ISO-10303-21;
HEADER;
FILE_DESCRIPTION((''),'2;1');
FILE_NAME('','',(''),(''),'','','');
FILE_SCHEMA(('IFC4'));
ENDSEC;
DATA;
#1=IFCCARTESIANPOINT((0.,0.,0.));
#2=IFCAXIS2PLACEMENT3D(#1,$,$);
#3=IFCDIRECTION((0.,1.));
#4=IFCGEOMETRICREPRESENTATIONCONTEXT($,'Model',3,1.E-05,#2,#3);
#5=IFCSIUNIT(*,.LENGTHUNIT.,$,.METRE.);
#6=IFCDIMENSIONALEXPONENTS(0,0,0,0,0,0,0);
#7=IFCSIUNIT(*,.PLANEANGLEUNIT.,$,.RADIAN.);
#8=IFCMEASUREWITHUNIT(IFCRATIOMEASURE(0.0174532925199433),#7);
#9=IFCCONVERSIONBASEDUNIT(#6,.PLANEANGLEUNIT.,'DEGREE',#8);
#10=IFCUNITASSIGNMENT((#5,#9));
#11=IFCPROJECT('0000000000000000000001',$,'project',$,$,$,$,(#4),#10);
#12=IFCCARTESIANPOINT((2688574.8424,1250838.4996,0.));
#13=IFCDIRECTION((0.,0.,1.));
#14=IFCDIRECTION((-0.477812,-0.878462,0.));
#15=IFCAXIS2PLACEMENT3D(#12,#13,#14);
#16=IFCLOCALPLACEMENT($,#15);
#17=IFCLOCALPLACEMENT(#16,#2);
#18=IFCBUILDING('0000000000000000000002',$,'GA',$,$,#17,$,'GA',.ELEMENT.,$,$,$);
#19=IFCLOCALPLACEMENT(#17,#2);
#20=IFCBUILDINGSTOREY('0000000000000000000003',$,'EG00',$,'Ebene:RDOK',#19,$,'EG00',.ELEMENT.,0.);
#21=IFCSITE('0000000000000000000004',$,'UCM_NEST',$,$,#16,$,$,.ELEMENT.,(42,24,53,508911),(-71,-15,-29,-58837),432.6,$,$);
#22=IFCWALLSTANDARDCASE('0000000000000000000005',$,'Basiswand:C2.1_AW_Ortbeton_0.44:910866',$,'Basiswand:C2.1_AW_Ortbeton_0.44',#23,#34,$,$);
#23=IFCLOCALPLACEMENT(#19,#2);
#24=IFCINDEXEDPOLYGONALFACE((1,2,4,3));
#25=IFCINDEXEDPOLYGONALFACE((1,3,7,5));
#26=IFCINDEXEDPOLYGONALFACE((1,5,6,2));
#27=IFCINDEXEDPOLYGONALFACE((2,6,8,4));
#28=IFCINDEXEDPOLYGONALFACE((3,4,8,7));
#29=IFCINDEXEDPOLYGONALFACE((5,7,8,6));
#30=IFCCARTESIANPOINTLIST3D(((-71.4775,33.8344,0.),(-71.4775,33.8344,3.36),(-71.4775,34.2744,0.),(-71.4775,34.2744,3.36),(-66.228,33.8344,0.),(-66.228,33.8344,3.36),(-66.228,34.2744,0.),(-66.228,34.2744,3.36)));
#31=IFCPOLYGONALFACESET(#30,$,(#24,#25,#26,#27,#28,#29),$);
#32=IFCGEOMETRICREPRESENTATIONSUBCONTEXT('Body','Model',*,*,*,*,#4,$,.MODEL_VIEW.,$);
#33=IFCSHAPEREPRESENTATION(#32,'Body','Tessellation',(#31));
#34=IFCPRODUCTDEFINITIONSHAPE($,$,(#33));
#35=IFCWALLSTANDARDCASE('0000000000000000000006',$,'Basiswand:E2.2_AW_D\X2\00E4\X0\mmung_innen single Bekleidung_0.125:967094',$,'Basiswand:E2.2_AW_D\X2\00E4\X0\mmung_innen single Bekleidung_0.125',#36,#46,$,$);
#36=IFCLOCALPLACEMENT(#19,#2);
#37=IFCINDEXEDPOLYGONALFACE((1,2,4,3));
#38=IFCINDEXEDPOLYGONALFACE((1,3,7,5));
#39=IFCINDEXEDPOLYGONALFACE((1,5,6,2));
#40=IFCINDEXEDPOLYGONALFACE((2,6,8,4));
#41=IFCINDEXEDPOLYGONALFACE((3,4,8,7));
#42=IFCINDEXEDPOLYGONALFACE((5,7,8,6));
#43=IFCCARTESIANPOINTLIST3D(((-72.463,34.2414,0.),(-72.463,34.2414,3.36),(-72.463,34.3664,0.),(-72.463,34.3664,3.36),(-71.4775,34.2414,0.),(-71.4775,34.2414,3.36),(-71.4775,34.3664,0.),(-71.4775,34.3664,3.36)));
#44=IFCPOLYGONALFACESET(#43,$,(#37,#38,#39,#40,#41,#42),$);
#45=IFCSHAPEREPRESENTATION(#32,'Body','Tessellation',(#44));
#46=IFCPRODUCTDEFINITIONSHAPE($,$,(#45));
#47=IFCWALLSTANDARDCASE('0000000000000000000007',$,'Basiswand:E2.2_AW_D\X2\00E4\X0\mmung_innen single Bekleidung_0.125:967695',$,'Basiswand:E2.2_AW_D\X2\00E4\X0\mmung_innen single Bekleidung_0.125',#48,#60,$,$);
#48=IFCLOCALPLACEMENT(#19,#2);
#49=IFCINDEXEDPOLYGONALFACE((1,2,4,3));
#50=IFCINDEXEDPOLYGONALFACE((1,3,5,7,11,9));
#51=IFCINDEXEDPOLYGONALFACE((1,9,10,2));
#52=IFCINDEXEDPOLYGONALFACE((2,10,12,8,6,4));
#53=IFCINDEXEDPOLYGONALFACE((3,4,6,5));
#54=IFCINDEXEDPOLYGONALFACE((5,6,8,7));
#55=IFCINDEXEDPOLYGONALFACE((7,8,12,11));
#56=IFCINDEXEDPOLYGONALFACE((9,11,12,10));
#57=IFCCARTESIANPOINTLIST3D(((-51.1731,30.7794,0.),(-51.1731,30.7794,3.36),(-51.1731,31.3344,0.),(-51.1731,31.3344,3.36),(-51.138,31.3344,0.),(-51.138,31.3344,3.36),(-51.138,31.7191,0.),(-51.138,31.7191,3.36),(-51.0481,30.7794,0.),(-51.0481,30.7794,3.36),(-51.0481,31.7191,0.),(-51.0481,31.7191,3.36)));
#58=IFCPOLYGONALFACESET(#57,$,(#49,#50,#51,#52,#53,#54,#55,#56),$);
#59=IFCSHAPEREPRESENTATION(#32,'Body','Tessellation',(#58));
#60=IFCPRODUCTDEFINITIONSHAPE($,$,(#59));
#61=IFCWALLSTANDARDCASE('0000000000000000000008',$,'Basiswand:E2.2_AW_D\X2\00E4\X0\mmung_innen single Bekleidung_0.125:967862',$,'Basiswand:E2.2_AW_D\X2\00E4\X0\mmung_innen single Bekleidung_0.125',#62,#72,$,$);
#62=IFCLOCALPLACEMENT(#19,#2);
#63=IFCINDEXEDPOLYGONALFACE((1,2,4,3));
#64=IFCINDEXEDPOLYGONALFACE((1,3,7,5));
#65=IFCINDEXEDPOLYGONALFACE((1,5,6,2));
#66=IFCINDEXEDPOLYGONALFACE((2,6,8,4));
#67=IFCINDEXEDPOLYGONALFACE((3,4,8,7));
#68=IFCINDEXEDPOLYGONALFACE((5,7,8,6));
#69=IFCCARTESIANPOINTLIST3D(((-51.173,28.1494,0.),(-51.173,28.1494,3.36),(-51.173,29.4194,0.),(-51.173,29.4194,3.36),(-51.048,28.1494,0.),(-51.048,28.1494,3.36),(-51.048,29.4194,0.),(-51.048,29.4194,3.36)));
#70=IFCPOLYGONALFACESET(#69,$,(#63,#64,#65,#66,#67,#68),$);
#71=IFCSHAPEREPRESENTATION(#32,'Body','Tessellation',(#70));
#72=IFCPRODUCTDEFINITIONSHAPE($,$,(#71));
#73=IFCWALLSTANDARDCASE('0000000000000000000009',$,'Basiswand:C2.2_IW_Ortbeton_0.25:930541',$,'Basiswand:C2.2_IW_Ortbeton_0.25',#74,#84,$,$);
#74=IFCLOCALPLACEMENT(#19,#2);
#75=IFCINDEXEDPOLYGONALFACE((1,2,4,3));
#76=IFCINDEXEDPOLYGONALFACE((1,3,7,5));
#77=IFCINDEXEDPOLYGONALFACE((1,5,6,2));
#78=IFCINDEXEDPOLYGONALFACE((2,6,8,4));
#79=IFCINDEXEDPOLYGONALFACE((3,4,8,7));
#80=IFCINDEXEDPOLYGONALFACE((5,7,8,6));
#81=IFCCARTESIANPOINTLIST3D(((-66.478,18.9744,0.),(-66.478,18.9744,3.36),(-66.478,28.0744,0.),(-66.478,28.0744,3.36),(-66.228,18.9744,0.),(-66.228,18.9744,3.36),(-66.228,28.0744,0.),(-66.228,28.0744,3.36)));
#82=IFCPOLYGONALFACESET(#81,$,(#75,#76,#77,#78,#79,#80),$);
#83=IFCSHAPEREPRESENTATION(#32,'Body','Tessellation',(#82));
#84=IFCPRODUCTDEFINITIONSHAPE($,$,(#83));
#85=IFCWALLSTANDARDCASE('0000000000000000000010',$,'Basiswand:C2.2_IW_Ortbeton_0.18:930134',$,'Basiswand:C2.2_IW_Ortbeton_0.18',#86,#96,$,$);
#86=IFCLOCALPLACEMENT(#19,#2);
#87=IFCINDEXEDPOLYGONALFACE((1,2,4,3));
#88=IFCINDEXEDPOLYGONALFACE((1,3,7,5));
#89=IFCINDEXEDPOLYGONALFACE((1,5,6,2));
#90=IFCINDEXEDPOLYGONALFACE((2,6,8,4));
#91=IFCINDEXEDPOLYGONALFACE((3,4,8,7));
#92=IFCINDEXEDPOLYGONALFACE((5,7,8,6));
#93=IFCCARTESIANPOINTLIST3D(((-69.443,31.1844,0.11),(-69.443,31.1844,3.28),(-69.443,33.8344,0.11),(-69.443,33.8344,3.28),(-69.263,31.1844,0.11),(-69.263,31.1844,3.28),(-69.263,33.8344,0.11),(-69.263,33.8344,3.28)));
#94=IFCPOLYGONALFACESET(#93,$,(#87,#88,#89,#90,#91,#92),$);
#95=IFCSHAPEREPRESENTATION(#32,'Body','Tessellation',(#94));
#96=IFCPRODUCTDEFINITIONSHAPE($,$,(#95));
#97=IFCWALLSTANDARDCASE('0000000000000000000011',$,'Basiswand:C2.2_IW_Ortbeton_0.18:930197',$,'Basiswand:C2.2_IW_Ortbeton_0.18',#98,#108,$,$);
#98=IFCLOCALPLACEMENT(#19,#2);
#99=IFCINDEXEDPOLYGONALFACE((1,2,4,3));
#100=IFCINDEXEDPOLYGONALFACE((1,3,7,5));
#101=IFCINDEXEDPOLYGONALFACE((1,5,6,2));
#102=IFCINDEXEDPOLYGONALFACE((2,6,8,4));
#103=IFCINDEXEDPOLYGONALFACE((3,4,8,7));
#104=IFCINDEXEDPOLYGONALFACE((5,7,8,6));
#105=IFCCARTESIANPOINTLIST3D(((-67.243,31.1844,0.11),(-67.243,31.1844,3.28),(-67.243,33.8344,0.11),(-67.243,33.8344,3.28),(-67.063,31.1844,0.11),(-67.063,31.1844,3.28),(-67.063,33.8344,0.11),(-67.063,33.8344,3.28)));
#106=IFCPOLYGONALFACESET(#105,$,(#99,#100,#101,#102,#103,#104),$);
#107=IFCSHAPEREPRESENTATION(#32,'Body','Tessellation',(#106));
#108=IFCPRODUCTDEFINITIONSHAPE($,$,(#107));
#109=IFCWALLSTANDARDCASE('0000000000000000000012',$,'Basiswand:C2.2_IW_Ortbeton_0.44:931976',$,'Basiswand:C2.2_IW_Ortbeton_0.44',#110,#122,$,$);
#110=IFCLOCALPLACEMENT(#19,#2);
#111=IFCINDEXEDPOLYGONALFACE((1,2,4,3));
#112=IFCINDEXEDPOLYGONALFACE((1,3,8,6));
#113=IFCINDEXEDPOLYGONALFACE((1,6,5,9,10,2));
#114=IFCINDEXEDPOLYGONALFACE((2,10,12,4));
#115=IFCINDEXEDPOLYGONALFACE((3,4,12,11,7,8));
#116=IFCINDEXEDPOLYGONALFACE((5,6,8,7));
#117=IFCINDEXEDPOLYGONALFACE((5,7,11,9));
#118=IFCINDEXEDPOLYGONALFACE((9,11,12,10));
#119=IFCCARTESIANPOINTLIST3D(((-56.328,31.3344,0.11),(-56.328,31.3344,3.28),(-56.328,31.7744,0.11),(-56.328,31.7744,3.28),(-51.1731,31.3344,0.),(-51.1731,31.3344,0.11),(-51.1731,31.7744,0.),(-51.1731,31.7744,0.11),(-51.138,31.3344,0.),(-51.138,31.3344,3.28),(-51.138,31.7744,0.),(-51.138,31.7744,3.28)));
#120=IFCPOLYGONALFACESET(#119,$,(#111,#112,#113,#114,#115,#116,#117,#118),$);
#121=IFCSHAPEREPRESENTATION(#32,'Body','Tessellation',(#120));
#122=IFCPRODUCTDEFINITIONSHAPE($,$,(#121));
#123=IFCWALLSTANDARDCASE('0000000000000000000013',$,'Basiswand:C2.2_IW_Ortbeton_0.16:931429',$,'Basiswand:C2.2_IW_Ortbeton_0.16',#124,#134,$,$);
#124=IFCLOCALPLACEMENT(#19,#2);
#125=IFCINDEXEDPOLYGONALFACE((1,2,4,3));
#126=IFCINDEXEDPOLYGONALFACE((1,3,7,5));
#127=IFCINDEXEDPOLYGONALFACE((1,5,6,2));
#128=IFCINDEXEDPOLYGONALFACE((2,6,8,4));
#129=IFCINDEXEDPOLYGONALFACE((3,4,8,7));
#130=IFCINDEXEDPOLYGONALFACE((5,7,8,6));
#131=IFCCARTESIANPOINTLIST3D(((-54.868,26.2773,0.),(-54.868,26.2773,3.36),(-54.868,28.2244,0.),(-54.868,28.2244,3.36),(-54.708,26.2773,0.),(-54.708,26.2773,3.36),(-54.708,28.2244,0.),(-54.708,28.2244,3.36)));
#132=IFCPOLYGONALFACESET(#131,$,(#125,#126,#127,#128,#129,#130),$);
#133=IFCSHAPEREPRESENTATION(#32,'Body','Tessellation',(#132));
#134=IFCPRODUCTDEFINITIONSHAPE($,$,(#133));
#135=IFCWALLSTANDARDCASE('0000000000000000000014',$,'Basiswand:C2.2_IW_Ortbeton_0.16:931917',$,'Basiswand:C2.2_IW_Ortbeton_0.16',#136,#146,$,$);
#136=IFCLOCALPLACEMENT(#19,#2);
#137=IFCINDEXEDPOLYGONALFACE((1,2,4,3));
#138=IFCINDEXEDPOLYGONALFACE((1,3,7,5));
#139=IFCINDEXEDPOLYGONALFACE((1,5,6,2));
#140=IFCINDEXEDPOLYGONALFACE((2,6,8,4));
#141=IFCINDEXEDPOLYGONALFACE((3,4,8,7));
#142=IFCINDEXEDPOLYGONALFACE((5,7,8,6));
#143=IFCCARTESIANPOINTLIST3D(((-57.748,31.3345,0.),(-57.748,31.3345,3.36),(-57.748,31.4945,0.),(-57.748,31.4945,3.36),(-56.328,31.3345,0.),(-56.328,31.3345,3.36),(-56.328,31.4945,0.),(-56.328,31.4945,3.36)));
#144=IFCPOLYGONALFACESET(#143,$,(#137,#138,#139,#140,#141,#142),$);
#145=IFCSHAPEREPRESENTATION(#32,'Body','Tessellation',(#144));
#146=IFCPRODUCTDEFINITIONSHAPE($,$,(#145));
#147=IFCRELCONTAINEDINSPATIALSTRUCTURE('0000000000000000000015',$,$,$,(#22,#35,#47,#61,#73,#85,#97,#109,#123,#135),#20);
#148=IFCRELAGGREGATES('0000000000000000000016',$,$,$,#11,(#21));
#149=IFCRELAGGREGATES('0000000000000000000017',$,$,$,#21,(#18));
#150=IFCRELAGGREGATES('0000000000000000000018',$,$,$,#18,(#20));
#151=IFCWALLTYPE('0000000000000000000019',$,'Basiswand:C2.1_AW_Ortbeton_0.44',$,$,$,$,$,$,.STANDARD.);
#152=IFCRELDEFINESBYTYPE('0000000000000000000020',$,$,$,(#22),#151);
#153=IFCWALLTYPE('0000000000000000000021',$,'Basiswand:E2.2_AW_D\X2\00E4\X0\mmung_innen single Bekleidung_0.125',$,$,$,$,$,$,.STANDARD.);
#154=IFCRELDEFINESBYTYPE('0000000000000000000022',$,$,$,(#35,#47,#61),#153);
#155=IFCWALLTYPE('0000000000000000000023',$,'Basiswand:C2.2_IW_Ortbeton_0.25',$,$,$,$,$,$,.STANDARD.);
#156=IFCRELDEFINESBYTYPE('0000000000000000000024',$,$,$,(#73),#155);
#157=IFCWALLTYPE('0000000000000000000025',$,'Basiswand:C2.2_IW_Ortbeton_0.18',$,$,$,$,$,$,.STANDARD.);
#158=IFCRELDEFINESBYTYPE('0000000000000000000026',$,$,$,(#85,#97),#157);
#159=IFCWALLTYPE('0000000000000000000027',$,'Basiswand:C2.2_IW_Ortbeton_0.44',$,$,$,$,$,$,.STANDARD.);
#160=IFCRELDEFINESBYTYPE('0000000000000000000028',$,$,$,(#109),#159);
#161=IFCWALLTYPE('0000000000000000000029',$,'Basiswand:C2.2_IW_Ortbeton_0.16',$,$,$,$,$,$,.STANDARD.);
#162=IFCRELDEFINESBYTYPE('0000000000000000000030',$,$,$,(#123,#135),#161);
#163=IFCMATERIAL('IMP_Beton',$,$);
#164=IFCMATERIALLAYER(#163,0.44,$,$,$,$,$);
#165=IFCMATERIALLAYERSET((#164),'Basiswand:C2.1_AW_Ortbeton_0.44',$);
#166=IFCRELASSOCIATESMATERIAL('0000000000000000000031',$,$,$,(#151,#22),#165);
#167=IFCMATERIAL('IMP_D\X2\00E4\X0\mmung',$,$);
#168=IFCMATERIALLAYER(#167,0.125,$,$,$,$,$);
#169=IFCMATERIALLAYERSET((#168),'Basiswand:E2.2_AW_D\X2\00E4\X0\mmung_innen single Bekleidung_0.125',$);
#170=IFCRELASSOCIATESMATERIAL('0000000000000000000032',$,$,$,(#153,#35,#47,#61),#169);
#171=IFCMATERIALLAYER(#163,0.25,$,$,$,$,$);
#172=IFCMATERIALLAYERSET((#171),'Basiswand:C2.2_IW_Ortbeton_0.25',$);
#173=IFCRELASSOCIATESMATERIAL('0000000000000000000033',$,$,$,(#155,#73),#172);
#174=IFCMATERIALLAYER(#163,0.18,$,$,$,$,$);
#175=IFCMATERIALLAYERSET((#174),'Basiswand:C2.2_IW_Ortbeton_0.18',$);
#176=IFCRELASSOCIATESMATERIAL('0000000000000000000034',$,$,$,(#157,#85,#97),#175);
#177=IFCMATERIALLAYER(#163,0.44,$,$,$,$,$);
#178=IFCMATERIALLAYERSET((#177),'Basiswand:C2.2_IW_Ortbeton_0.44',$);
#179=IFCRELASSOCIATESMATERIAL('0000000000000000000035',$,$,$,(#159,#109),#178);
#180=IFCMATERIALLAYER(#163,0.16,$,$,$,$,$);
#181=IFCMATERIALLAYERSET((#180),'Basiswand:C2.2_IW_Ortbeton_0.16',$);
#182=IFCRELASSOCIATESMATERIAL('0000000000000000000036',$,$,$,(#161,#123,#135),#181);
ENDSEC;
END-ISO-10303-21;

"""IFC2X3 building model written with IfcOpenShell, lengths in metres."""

from ifc_helpers import new_model, entity, si_unit, converted_unit, direction, frame, frame_2d, origin, place, context, subcontext, project, spatial, polyline, rectangle, extrude, clip, bounded_halfspace, material, layer, layer_set, layer_usage, type_object, element, save


model = new_model("IFC2X3")

# Units and contexts
model_context = context("Model", 3, precision=1e-05, world=origin(), true_north=direction((0.0, 1.0)))
body_context = subcontext(model_context, "Body", "Model", "MODEL_VIEW")
ifc_project = project(units=[si_unit("LENGTHUNIT", "METRE"), converted_unit("PLANEANGLEUNIT", "DEGREE", entity("IfcRatioMeasure", 0.0174532925199433), si_unit("PLANEANGLEUNIT", "RADIAN"), dimensions=[0, 0, 0, 0, 0, 0, 0])], contexts=[model_context])

# Site, building, storey
site_placement = place(None, frame((2688574.8424, 1250838.4996, 0.0), z_axis=(0.0, 0.0, 1.0), x_axis=(-0.477812, -0.878462, 0.0)))
site = spatial("IfcSite", under=ifc_project, at=site_placement, Name="UCM_NEST", CompositionType="ELEMENT", RefLatitude=(42, 24, 53, 508911), RefLongitude=(-71, -15, -29, -58837), RefElevation=432.6)
building_placement = place(site_placement, origin())
building = spatial("IfcBuilding", under=site, at=building_placement, Name="GA", LongName="GA", CompositionType="ELEMENT")
storey_placement = place(building_placement, origin())
storey = spatial("IfcBuildingStorey", under=building, at=storey_placement, Name="EG00", ObjectType="Ebene:RDOK", LongName="EG00", CompositionType="ELEMENT", Elevation=0.0)

# Shared definitions
ifc_material_1 = material(Name="IMP_Dämmung")
ifc_material_2 = material(Name="IMP_Beton")

# Walls
ifc_layer_1 = layer(ifc_material_2, 0.44)
ifc_layer_set_1 = layer_set([ifc_layer_1], Name="Basiswand:C2.1_AW_Ortbeton_0.44")
ifc_layer_usage_1 = layer_usage(ifc_layer_set_1, "AXIS2", "NEGATIVE", 0.22)
wall_type_1 = type_object("IfcWallType", Name="Basiswand:C2.1_AW_Ortbeton_0.44", PredefinedType="STANDARD", material=ifc_layer_set_1)
wall_1_placement = place(storey_placement, frame((-71.4775, 34.0544, 0.0)))
element("IfcWallStandardCase", 1, at=wall_1_placement, inside=storey, type_object=wall_type_1, material=ifc_layer_usage_1, Name="Basiswand:C2.1_AW_Ortbeton_0.44:910866", ObjectType="Basiswand:C2.1_AW_Ortbeton_0.44", context=body_context, shape_type="SweptSolid", body=[
    extrude(rectangle(XDim=5.2494, YDim=0.44, at=frame_2d((2.6247, 0.0), x_axis=(-1.0, 0.0))), origin(), (0.0, 0.0, 1.0), 3.36),
])
ifc_layer_2 = layer(ifc_material_1, 0.125)
ifc_layer_set_2 = layer_set([ifc_layer_2], Name="Basiswand:E2.2_AW_Dämmung_innen single Bekleidung_0.125")
ifc_layer_usage_2 = layer_usage(ifc_layer_set_2, "AXIS2", "NEGATIVE", 0.0625)
wall_type_2 = type_object("IfcWallType", Name="Basiswand:E2.2_AW_Dämmung_innen single Bekleidung_0.125", PredefinedType="STANDARD", material=ifc_layer_set_2)
wall_2_placement = place(storey_placement, frame((-72.463, 34.3039, 0.0)))
element("IfcWallStandardCase", 2, at=wall_2_placement, inside=storey, type_object=wall_type_2, material=ifc_layer_usage_2, Name="Basiswand:E2.2_AW_Dämmung_innen single Bekleidung_0.125:967094", ObjectType="Basiswand:E2.2_AW_Dämmung_innen single Bekleidung_0.125", context=body_context, shape_type="SweptSolid", body=[
    extrude(rectangle(XDim=0.9856, YDim=0.125, at=frame_2d((0.4928, 0.0), x_axis=(-1.0, 0.0))), origin(), (0.0, 0.0, 1.0), 3.36),
])
ifc_layer_usage_3 = layer_usage(ifc_layer_set_2, "AXIS2", "NEGATIVE", 0.0625)
wall_3_placement = place(storey_placement, frame((-51.1106, 30.7794, 0.0), z_axis=(0.0, 0.0, 1.0), x_axis=(0.0, 1.0, 0.0)))
element("IfcWallStandardCase", 3, at=wall_3_placement, inside=storey, type_object=wall_type_2, material=ifc_layer_usage_3, Name="Basiswand:E2.2_AW_Dämmung_innen single Bekleidung_0.125:967695", ObjectType="Basiswand:E2.2_AW_Dämmung_innen single Bekleidung_0.125", context=body_context, shape_type="Clipping", body=[
    clip(clip(extrude(rectangle(XDim=0.9397, YDim=0.125, at=frame_2d((0.4699, 0.0), x_axis=(-1.0, 0.0))), origin(), (0.0, 0.0, 1.0), 3.36), bounded_halfspace(frame((0.555, 0.0274, 3.36), z_axis=(-1.0, 0.0, 0.0), x_axis=(0.0, -1.0, 0.0)), True, frame((0.555, 0.0274, 3.36), z_axis=(-1.0, 0.0, 0.0), x_axis=(0.0, -1.0, 0.0)), polyline([(0.0, 0.0), (-0.0351, 0.0), (-0.0351, -3.36), (0.0, -3.36), (0.0, 0.0)]))), bounded_halfspace(frame((0.555, 0.0274, 0.0), z_axis=(0.0, -1.0, 0.0), x_axis=(1.0, 0.0, 0.0)), True, frame((0.555, 0.0274, 0.0), z_axis=(0.0, -1.0, 0.0), x_axis=(1.0, 0.0, 0.0)), polyline([(0.0, 0.0), (0.3847, 0.0), (0.3847, 3.36), (0.0, 3.36), (0.0, 0.0)]))),
])
ifc_layer_usage_4 = layer_usage(ifc_layer_set_2, "AXIS2", "NEGATIVE", 0.0625)
wall_4_placement = place(storey_placement, frame((-51.1105, 29.4194, 0.0), z_axis=(0.0, 0.0, 1.0), x_axis=(0.0, -1.0, 0.0)))
element("IfcWallStandardCase", 4, at=wall_4_placement, inside=storey, type_object=wall_type_2, material=ifc_layer_usage_4, Name="Basiswand:E2.2_AW_Dämmung_innen single Bekleidung_0.125:967862", ObjectType="Basiswand:E2.2_AW_Dämmung_innen single Bekleidung_0.125", context=body_context, shape_type="SweptSolid", body=[
    extrude(rectangle(XDim=1.27, YDim=0.125, at=frame_2d((0.635, 0.0), x_axis=(-1.0, 0.0))), origin(), (0.0, 0.0, 1.0), 3.36),
])
ifc_layer_3 = layer(ifc_material_2, 0.25)
ifc_layer_set_3 = layer_set([ifc_layer_3], Name="Basiswand:C2.2_IW_Ortbeton_0.25")
ifc_layer_usage_5 = layer_usage(ifc_layer_set_3, "AXIS2", "NEGATIVE", 0.125)
wall_type_3 = type_object("IfcWallType", Name="Basiswand:C2.2_IW_Ortbeton_0.25", PredefinedType="STANDARD", material=ifc_layer_set_3)
wall_5_placement = place(storey_placement, frame((-66.353, 28.0744, 0.0), z_axis=(0.0, 0.0, 1.0), x_axis=(0.0, -1.0, 0.0)))
element("IfcWallStandardCase", 5, at=wall_5_placement, inside=storey, type_object=wall_type_3, material=ifc_layer_usage_5, Name="Basiswand:C2.2_IW_Ortbeton_0.25:930541", ObjectType="Basiswand:C2.2_IW_Ortbeton_0.25", context=body_context, shape_type="SweptSolid", body=[
    extrude(rectangle(XDim=9.1, YDim=0.25, at=frame_2d((4.55, 0.0), x_axis=(-1.0, 0.0))), origin(), (0.0, 0.0, 1.0), 3.36),
])
ifc_layer_4 = layer(ifc_material_2, 0.18)
ifc_layer_set_4 = layer_set([ifc_layer_4], Name="Basiswand:C2.2_IW_Ortbeton_0.18")
ifc_layer_usage_6 = layer_usage(ifc_layer_set_4, "AXIS2", "NEGATIVE", 0.09)
wall_type_4 = type_object("IfcWallType", Name="Basiswand:C2.2_IW_Ortbeton_0.18", PredefinedType="STANDARD", material=ifc_layer_set_4)
wall_6_placement = place(storey_placement, frame((-69.353, 31.1844, 0.11), z_axis=(0.0, 0.0, 1.0), x_axis=(0.0, 1.0, 0.0)))
element("IfcWallStandardCase", 6, at=wall_6_placement, inside=storey, type_object=wall_type_4, material=ifc_layer_usage_6, Name="Basiswand:C2.2_IW_Ortbeton_0.18:930134", ObjectType="Basiswand:C2.2_IW_Ortbeton_0.18", context=body_context, shape_type="Clipping", body=[
    clip(clip(extrude(rectangle(XDim=2.65, YDim=0.18, at=frame_2d((1.325, 0.0), x_axis=(-1.0, 0.0))), origin(), (0.0, 0.0, 1.0), 3.17), bounded_halfspace(frame((0.0, -0.09, 3.17), z_axis=(0.0, 0.0, -1.0), x_axis=(0.0, 1.0, 0.0)), True, frame((0.0, -0.09, 3.17), z_axis=(0.0, 0.0, -1.0), x_axis=(0.0, 1.0, 0.0)), polyline([(0.0, 0.0), (0.18, 0.0), (0.18, 2.65), (0.0, 2.65), (0.0, 0.0)]))), bounded_halfspace(frame((2.65, -0.09, 0.0), z_axis=(0.0, 0.0, 1.0), x_axis=(0.0, 1.0, 0.0)), True, frame((2.65, -0.09, 0.0), z_axis=(0.0, 0.0, 1.0), x_axis=(0.0, 1.0, 0.0)), polyline([(0.0, 0.0), (0.18, 0.0), (0.18, 2.65), (0.0, 2.65), (0.0, 0.0)]))),
])
ifc_layer_usage_7 = layer_usage(ifc_layer_set_4, "AXIS2", "NEGATIVE", 0.09)
wall_7_placement = place(storey_placement, frame((-67.153, 31.1844, 0.11), z_axis=(0.0, 0.0, 1.0), x_axis=(0.0, 1.0, 0.0)))
element("IfcWallStandardCase", 7, at=wall_7_placement, inside=storey, type_object=wall_type_4, material=ifc_layer_usage_7, Name="Basiswand:C2.2_IW_Ortbeton_0.18:930197", ObjectType="Basiswand:C2.2_IW_Ortbeton_0.18", context=body_context, shape_type="Clipping", body=[
    clip(clip(extrude(rectangle(XDim=2.65, YDim=0.18, at=frame_2d((1.325, 0.0), x_axis=(-1.0, 0.0))), origin(), (0.0, 0.0, 1.0), 3.17), bounded_halfspace(frame((2.65, -0.09, 0.0), z_axis=(0.0, 0.0, 1.0), x_axis=(0.0, 1.0, 0.0)), True, frame((2.65, -0.09, 0.0), z_axis=(0.0, 0.0, 1.0), x_axis=(0.0, 1.0, 0.0)), polyline([(0.0, 0.0), (0.18, 0.0), (0.18, 2.65), (0.0, 2.65), (0.0, 0.0)]))), bounded_halfspace(frame((0.0, -0.09, 3.17), z_axis=(0.0, 0.0, -1.0), x_axis=(0.0, 1.0, 0.0)), True, frame((0.0, -0.09, 3.17), z_axis=(0.0, 0.0, -1.0), x_axis=(0.0, 1.0, 0.0)), polyline([(0.0, 0.0), (0.18, 0.0), (0.18, 2.65), (0.0, 2.65), (0.0, 0.0)]))),
])
ifc_layer_5 = layer(ifc_material_2, 0.44)
ifc_layer_set_5 = layer_set([ifc_layer_5], Name="Basiswand:C2.2_IW_Ortbeton_0.44")
ifc_layer_usage_8 = layer_usage(ifc_layer_set_5, "AXIS2", "NEGATIVE", 0.22)
wall_type_5 = type_object("IfcWallType", Name="Basiswand:C2.2_IW_Ortbeton_0.44", PredefinedType="STANDARD", material=ifc_layer_set_5)
wall_8_placement = place(storey_placement, frame((-56.328, 31.5544, 0.0)))
element("IfcWallStandardCase", 8, at=wall_8_placement, inside=storey, type_object=wall_type_5, material=ifc_layer_usage_8, Name="Basiswand:C2.2_IW_Ortbeton_0.44:931976", ObjectType="Basiswand:C2.2_IW_Ortbeton_0.44", context=body_context, shape_type="Clipping", body=[
    clip(clip(clip(extrude(rectangle(XDim=5.19, YDim=0.44, at=frame_2d((2.595, 0.0), x_axis=(-1.0, 0.0))), origin(), (0.0, 0.0, 1.0), 3.28), bounded_halfspace(frame((5.1549, 0.22, 0.11), z_axis=(0.0, 0.0, 1.0), x_axis=(-1.0, 0.0, 0.0)), True, frame((5.1549, 0.22, 0.11), z_axis=(0.0, 0.0, 1.0), x_axis=(-1.0, 0.0, 0.0)), polyline([(0.0, 0.0), (5.1549, 0.0), (5.1549, 0.44), (0.0, 0.44), (0.0, 0.0)]))), bounded_halfspace(frame((5.1549, -0.22, 0.11), z_axis=(1.0, 0.0, 0.0), x_axis=(0.0, 0.0, 1.0)), True, frame((5.1549, -0.22, 0.11), z_axis=(1.0, 0.0, 0.0), x_axis=(0.0, 0.0, 1.0)), polyline([(0.0, 0.0), (-0.11, 0.0), (-0.11, -0.44), (0.0, -0.44), (0.0, 0.0)]))), bounded_halfspace(frame((0.0, -0.22, 3.28), z_axis=(0.0, 0.0, -1.0), x_axis=(-1.0, 0.0, 0.0)), True, frame((0.0, -0.22, 3.28), z_axis=(0.0, 0.0, -1.0), x_axis=(-1.0, 0.0, 0.0)), polyline([(0.0, 0.0), (0.0, 0.44), (-5.19, 0.44), (-5.19, 0.0), (0.0, 0.0)]))),
])
ifc_layer_6 = layer(ifc_material_2, 0.16)
ifc_layer_set_6 = layer_set([ifc_layer_6], Name="Basiswand:C2.2_IW_Ortbeton_0.16")
ifc_layer_usage_9 = layer_usage(ifc_layer_set_6, "AXIS2", "NEGATIVE", 0.08)
wall_type_6 = type_object("IfcWallType", Name="Basiswand:C2.2_IW_Ortbeton_0.16", PredefinedType="STANDARD", material=ifc_layer_set_6)
wall_9_placement = place(storey_placement, frame((-54.788, 28.2244, 0.0), z_axis=(0.0, 0.0, 1.0), x_axis=(0.0, -1.0, 0.0)))
element("IfcWallStandardCase", 9, at=wall_9_placement, inside=storey, type_object=wall_type_6, material=ifc_layer_usage_9, Name="Basiswand:C2.2_IW_Ortbeton_0.16:931429", ObjectType="Basiswand:C2.2_IW_Ortbeton_0.16", context=body_context, shape_type="SweptSolid", body=[
    extrude(rectangle(XDim=1.9471, YDim=0.16, at=frame_2d((0.9736, 0.0), x_axis=(-1.0, 0.0))), origin(), (0.0, 0.0, 1.0), 3.36),
])
ifc_layer_usage_10 = layer_usage(ifc_layer_set_6, "AXIS2", "NEGATIVE", 0.08)
wall_10_placement = place(storey_placement, frame((-57.748, 31.4145, 0.0)))
element("IfcWallStandardCase", 10, at=wall_10_placement, inside=storey, type_object=wall_type_6, material=ifc_layer_usage_10, Name="Basiswand:C2.2_IW_Ortbeton_0.16:931917", ObjectType="Basiswand:C2.2_IW_Ortbeton_0.16", context=body_context, shape_type="SweptSolid", body=[
    extrude(rectangle(XDim=1.42, YDim=0.16, at=frame_2d((0.71, 0.0), x_axis=(-1.0, 0.0))), origin(), (0.0, 0.0, 1.0), 3.36),
])

save(model, "model.ifc")
